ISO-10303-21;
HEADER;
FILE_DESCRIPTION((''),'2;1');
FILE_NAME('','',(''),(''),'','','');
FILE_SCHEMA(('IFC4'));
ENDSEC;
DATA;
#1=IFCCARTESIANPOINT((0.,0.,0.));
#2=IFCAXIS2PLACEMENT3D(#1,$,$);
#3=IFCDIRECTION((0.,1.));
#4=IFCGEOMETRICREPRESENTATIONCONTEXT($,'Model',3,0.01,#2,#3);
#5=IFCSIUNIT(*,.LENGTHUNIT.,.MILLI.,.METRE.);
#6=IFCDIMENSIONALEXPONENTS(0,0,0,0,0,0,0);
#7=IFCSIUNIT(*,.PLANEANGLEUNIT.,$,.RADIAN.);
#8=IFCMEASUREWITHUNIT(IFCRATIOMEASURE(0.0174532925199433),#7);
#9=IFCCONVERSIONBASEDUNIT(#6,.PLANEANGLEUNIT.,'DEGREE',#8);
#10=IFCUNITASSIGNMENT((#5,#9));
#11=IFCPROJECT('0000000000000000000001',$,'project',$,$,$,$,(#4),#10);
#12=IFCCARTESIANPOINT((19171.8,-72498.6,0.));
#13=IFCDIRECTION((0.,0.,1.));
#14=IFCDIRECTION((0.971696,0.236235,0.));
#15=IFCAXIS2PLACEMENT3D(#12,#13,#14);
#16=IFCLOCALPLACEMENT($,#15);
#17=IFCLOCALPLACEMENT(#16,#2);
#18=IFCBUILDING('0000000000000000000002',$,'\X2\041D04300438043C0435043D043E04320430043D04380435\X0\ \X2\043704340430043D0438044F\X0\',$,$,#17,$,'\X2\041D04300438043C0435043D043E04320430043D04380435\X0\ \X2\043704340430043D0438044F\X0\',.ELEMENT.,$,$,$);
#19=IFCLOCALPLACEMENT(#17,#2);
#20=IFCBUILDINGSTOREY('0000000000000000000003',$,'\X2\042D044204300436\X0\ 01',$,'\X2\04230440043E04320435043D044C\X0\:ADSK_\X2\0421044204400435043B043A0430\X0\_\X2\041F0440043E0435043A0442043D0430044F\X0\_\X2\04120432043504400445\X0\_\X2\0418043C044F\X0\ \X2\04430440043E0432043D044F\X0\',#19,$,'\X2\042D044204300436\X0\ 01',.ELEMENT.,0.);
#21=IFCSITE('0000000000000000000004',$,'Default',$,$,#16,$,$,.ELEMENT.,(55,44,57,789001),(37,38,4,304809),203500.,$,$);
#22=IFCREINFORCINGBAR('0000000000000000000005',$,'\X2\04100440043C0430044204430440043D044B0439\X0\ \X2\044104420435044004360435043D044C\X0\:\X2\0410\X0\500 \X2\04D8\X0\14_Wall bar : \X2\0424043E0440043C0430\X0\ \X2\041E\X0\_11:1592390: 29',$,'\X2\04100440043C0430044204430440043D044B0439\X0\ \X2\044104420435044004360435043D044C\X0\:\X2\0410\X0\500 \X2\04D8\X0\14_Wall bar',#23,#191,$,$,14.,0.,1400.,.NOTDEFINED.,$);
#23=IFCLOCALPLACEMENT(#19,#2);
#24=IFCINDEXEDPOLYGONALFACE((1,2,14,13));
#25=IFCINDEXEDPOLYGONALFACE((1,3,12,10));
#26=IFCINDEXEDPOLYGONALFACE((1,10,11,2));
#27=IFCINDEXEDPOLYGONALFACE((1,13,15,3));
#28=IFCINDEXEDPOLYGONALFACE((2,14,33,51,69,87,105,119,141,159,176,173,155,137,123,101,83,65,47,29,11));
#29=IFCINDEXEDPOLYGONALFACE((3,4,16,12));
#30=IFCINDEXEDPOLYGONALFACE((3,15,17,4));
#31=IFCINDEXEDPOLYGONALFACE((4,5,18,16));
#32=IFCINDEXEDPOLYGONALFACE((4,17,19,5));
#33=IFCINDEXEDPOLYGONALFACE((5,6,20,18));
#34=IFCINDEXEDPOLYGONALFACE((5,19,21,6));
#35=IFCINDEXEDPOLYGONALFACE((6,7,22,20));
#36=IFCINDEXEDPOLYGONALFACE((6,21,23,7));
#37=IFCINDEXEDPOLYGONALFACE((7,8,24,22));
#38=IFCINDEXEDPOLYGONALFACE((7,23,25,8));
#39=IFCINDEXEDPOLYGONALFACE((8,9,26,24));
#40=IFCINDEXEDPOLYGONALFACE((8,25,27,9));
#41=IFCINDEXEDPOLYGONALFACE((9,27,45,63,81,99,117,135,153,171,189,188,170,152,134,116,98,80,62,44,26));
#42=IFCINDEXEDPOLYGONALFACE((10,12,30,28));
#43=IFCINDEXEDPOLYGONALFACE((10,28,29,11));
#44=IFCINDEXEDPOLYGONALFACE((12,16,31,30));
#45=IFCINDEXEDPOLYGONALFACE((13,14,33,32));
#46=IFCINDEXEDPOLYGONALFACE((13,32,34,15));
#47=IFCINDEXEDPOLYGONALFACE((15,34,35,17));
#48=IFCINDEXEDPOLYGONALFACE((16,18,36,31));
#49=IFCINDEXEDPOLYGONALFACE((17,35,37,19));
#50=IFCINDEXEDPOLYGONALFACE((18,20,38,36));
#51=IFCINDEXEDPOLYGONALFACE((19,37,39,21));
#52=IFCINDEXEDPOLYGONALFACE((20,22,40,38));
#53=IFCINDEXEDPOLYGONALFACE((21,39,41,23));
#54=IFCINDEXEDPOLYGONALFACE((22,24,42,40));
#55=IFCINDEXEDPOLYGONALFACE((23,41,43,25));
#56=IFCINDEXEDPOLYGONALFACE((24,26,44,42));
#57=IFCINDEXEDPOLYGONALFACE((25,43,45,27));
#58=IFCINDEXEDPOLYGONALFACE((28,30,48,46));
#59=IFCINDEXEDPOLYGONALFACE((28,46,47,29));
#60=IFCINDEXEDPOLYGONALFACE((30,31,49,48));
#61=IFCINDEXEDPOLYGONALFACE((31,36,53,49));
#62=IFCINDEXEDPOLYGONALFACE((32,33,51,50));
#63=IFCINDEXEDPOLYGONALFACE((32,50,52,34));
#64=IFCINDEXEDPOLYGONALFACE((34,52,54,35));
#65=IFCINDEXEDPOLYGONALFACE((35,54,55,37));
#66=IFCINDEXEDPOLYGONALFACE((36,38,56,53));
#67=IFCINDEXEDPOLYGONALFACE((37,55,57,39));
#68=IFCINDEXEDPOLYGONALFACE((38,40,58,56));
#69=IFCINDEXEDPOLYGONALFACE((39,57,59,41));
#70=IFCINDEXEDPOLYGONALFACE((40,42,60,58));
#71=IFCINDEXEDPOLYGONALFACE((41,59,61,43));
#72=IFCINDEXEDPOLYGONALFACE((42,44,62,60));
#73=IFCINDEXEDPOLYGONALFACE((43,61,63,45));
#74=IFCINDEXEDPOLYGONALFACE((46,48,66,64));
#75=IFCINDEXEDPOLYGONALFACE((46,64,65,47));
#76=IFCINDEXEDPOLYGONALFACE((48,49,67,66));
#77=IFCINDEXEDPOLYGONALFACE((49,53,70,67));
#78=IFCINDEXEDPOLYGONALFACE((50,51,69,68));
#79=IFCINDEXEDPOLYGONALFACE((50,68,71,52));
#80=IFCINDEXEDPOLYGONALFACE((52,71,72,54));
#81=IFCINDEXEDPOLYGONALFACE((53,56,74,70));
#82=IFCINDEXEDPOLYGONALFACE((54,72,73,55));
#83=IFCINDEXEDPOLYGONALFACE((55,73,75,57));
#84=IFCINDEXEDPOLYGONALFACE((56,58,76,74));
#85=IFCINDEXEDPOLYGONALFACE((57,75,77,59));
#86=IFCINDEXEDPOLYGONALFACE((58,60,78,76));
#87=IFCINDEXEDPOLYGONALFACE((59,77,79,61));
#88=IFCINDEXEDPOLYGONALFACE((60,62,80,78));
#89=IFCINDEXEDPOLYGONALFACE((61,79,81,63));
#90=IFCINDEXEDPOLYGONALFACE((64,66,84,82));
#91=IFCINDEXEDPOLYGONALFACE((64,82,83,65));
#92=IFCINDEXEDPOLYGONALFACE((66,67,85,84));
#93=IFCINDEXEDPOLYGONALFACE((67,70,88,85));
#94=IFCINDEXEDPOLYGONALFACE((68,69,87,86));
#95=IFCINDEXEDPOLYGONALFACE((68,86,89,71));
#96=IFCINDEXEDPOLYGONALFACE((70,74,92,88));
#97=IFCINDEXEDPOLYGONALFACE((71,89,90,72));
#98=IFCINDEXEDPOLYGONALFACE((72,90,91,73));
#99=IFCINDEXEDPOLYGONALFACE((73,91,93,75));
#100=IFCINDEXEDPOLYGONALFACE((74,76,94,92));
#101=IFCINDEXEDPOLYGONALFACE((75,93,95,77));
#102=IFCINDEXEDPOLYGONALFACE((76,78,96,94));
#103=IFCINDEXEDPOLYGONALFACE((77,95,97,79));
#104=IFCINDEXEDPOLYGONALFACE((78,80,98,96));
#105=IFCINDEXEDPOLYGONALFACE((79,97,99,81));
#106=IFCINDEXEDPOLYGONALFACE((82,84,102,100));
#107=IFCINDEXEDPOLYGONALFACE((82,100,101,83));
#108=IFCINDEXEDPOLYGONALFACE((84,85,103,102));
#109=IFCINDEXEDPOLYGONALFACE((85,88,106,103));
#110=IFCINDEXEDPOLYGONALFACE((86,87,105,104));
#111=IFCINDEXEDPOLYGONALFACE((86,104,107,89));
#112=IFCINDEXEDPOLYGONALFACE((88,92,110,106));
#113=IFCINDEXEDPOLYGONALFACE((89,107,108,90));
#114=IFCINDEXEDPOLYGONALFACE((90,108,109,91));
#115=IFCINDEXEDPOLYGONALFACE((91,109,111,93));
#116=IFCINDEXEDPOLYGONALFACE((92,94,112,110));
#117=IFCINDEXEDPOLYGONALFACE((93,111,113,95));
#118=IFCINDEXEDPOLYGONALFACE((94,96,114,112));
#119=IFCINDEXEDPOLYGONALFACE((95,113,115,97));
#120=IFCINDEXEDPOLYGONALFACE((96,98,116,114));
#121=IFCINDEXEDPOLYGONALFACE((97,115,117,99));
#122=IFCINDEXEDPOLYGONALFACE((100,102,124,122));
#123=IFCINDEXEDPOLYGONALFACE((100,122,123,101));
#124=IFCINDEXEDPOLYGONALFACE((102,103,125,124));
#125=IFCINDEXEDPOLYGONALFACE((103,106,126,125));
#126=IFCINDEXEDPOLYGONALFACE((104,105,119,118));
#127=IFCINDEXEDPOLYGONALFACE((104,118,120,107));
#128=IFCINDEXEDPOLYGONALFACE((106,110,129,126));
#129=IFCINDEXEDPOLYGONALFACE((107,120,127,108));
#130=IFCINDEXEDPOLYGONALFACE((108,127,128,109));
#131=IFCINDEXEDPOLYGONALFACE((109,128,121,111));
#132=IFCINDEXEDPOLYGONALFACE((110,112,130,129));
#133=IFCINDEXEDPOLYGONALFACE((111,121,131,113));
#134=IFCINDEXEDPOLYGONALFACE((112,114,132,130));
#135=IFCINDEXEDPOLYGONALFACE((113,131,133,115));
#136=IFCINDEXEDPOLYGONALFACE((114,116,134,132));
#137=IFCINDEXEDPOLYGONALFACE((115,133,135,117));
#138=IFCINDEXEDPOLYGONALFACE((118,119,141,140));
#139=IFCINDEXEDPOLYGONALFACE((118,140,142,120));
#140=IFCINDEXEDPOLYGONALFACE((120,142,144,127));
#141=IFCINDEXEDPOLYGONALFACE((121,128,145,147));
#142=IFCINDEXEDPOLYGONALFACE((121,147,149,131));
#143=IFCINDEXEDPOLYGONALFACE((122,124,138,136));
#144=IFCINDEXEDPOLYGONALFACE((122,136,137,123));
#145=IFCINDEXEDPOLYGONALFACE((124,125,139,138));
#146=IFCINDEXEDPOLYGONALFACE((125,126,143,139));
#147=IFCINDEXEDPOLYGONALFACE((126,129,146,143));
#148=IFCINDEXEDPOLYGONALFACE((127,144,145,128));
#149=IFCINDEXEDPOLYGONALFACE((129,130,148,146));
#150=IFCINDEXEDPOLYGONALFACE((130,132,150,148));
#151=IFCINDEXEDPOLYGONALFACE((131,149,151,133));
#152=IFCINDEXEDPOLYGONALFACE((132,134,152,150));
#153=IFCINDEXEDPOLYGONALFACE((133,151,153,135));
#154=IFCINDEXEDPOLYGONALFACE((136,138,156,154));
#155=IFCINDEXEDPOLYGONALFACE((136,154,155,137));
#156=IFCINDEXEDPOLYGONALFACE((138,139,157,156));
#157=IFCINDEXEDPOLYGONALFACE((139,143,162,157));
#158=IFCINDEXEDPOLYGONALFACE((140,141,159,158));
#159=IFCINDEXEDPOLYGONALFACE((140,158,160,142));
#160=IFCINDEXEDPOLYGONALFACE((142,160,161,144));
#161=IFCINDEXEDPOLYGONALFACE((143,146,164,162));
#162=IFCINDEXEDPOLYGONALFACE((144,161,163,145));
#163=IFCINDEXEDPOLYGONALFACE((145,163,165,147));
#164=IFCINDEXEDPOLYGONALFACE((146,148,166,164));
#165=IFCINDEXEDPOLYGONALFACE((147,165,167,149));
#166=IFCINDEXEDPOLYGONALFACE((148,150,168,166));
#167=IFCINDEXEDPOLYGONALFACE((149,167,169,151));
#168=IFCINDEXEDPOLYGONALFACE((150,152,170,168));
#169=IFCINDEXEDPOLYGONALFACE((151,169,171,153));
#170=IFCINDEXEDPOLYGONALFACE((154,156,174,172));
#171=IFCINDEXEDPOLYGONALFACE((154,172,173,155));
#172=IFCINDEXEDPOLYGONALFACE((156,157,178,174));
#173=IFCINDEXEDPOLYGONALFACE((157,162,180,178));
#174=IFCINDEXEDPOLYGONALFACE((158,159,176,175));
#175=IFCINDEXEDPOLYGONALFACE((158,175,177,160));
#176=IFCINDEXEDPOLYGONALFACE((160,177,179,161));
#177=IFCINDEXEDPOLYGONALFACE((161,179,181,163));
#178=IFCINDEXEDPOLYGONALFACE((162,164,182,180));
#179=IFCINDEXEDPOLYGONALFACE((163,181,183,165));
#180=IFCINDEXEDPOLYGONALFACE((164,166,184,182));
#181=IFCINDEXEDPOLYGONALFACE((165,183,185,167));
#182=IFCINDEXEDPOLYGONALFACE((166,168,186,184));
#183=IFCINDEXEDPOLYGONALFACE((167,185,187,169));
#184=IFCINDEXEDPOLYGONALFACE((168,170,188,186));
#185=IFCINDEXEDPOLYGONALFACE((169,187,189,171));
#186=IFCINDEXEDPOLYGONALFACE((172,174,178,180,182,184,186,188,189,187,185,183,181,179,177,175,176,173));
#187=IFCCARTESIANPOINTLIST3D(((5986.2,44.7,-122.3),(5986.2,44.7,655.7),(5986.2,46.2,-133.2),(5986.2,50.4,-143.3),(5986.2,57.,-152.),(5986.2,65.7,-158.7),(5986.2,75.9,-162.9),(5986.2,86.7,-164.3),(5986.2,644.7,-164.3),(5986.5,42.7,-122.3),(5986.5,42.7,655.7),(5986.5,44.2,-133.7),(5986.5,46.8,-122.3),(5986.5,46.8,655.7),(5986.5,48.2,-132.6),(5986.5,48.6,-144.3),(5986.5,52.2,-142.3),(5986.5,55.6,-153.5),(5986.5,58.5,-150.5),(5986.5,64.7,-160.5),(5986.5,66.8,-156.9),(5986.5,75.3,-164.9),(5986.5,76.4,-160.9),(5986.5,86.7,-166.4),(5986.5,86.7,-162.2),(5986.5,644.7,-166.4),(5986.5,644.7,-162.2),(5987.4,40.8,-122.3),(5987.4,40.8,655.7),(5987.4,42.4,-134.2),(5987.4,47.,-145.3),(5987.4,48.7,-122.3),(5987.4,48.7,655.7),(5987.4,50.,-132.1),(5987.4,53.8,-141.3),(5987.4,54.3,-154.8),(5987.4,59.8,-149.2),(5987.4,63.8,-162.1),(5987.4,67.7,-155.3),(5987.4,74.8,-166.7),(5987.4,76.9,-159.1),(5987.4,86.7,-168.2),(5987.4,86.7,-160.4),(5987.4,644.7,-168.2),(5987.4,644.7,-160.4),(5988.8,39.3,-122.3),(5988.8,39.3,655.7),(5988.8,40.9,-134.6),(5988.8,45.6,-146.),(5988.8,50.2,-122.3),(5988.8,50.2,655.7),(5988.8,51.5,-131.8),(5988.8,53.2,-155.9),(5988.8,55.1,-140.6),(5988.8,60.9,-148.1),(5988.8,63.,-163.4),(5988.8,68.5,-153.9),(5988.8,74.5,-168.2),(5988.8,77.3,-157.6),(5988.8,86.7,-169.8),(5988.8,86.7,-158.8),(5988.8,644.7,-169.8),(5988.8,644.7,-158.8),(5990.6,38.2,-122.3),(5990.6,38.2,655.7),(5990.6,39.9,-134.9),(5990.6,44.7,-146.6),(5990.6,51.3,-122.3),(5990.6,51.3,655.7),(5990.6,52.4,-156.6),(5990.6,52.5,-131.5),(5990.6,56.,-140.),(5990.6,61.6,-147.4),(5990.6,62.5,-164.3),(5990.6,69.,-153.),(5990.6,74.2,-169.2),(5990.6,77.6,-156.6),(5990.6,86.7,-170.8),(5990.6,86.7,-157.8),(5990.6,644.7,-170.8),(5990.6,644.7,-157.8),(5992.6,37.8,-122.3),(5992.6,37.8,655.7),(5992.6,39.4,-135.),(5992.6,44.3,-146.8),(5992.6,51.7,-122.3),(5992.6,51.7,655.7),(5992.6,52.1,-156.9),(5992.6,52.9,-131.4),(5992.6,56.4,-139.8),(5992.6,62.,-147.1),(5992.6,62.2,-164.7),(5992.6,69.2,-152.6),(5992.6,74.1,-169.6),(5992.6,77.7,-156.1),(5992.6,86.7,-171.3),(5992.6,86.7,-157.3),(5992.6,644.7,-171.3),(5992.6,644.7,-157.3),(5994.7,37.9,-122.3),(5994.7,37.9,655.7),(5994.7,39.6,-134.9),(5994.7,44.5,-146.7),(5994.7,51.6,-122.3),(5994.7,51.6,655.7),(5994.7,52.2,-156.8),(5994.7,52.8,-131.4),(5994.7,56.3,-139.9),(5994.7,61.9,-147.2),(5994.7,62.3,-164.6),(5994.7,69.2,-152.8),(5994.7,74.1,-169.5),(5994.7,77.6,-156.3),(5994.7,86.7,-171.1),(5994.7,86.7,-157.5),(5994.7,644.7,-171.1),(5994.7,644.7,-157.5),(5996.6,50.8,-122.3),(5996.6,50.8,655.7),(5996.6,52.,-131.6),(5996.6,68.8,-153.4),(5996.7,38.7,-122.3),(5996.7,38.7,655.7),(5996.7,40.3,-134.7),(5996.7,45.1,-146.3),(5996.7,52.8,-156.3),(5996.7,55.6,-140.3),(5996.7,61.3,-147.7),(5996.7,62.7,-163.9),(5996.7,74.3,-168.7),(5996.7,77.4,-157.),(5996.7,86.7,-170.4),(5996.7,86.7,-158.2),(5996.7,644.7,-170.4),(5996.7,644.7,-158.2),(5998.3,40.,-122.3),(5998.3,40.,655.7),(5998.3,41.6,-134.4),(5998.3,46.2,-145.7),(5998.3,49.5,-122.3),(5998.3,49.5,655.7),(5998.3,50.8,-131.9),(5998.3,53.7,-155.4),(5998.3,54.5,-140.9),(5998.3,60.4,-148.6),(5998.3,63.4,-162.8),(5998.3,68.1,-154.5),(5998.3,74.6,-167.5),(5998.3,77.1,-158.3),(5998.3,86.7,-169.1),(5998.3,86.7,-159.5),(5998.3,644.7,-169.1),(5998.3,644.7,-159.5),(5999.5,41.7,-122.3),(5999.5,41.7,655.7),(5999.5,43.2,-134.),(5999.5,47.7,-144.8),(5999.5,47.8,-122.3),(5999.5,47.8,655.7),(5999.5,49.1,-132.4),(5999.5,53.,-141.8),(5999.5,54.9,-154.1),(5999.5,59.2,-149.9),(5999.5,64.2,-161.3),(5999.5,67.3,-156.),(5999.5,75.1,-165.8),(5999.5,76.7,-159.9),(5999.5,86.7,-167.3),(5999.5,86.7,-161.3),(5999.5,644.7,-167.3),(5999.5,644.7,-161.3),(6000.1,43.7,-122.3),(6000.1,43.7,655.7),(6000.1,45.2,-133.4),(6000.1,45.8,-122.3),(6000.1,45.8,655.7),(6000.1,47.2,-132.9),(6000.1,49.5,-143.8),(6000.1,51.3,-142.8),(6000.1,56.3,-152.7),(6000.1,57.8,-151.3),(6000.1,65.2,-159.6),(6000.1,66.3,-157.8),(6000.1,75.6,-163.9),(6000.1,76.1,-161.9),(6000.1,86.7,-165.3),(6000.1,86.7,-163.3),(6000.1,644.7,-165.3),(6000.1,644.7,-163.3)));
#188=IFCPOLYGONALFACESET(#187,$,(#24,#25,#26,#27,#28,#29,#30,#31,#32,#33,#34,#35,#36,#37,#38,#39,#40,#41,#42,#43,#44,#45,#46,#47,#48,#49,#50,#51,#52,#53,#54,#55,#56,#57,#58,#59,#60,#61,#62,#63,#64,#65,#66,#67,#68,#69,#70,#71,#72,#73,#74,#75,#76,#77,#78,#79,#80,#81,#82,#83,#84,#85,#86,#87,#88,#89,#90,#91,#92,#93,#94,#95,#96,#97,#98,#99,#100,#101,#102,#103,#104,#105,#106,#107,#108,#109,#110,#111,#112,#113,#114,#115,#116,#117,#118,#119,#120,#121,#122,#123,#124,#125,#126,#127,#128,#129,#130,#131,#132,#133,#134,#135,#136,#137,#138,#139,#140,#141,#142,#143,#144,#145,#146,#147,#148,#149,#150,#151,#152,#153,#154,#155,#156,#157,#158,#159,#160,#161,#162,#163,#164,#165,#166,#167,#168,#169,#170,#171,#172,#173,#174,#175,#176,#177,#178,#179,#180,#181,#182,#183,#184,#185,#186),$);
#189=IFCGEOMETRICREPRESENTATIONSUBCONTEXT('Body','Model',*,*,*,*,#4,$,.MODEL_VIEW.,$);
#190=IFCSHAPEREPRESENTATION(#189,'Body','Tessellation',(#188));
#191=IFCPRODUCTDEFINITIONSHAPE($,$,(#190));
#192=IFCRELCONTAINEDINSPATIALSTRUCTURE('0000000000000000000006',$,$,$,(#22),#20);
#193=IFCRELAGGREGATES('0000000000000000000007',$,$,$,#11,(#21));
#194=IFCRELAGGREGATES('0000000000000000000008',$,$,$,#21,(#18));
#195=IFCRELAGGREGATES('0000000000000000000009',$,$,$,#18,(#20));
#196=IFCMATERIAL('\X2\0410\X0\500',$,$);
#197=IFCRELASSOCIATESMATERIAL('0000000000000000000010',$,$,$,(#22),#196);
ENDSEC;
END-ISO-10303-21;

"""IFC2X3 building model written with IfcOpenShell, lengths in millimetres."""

from ifc_helpers import new_model, entity, si_unit, converted_unit, direction, frame, origin, place, context, subcontext, project, spatial, material, element, save


model = new_model("IFC2X3")

# Units and contexts
model_context = context("Model", 3, precision=0.01, world=origin(), true_north=direction((0.0, 1.0)))
body_context = subcontext(model_context, "Body", "Model", "MODEL_VIEW")
ifc_project = project(units=[si_unit("LENGTHUNIT", "METRE", prefix="MILLI"), converted_unit("PLANEANGLEUNIT", "DEGREE", entity("IfcRatioMeasure", 0.0174532925199433), si_unit("PLANEANGLEUNIT", "RADIAN"), dimensions=[0, 0, 0, 0, 0, 0, 0])], contexts=[model_context])

# Site, building, storey
site_placement = place(None, frame((19171.8, -72498.6, 0.0), z_axis=(0.0, 0.0, 1.0), x_axis=(0.971696, 0.236235, 0.0)))
site = spatial("IfcSite", under=ifc_project, at=site_placement, Name="Default", CompositionType="ELEMENT", RefLatitude=(55, 44, 57, 789001), RefLongitude=(37, 38, 4, 304809), RefElevation=203500.0)
building_placement = place(site_placement, origin())
building = spatial("IfcBuilding", under=site, at=building_placement, Name="Наименование здания", LongName="Наименование здания", CompositionType="ELEMENT")
storey_placement = place(building_placement, origin())
storey = spatial("IfcBuildingStorey", under=building, at=storey_placement, Name="Этаж 01", ObjectType="Уровень:ADSK_Стрелка_Проектная_Вверх_Имя уровня", LongName="Этаж 01", CompositionType="ELEMENT", Elevation=0.0)

# Reinforcing bar
ifc_material = material(Name="А500")
placement = place(storey_placement, origin())
element("IfcReinforcingBar", 1, at=placement, inside=storey, material=ifc_material, Name="Арматурный стержень:А500 Ә14_Wall bar : Форма О_11:1592390: 29", ObjectType="Арматурный стержень:А500 Ә14_Wall bar", BarLength=1400.0, BarRole="NOTDEFINED", CrossSectionArea=0.0, NominalDiameter=14.0, context=body_context, shape_type="AdvancedSweptSolid", body=[
    entity("IfcSweptDiskSolid", entity("IfcCompositeCurve", [entity("IfcCompositeCurveSegment", "CONTINUOUS", True, entity("IfcPolyline", [entity("IfcCartesianPoint", [5993.1, 44.7, 655.7]), entity("IfcCartesianPoint", [5993.1, 44.7, -122.3])])), entity("IfcCompositeCurveSegment", "CONTINUOUS", True, entity("IfcTrimmedCurve", entity("IfcCircle", entity("IfcAxis2Placement3D", entity("IfcCartesianPoint", [5993.1, 86.7, -122.3]), entity("IfcDirection", [1.0, 0.0, 0.0]), entity("IfcDirection", [0.0, 0.0, -1.0])), 42.0), [entity("IfcParameterValue", 270.0)], [entity("IfcParameterValue", 360.0)], True, "PARAMETER")), entity("IfcCompositeCurveSegment", "CONTINUOUS", True, entity("IfcPolyline", [entity("IfcCartesianPoint", [5993.1, 86.7, -164.3]), entity("IfcCartesianPoint", [5993.1, 644.7, -164.3])]))], False), 7.0, None, 0.0, 92.0),
])

save(model, "model.ifc")
